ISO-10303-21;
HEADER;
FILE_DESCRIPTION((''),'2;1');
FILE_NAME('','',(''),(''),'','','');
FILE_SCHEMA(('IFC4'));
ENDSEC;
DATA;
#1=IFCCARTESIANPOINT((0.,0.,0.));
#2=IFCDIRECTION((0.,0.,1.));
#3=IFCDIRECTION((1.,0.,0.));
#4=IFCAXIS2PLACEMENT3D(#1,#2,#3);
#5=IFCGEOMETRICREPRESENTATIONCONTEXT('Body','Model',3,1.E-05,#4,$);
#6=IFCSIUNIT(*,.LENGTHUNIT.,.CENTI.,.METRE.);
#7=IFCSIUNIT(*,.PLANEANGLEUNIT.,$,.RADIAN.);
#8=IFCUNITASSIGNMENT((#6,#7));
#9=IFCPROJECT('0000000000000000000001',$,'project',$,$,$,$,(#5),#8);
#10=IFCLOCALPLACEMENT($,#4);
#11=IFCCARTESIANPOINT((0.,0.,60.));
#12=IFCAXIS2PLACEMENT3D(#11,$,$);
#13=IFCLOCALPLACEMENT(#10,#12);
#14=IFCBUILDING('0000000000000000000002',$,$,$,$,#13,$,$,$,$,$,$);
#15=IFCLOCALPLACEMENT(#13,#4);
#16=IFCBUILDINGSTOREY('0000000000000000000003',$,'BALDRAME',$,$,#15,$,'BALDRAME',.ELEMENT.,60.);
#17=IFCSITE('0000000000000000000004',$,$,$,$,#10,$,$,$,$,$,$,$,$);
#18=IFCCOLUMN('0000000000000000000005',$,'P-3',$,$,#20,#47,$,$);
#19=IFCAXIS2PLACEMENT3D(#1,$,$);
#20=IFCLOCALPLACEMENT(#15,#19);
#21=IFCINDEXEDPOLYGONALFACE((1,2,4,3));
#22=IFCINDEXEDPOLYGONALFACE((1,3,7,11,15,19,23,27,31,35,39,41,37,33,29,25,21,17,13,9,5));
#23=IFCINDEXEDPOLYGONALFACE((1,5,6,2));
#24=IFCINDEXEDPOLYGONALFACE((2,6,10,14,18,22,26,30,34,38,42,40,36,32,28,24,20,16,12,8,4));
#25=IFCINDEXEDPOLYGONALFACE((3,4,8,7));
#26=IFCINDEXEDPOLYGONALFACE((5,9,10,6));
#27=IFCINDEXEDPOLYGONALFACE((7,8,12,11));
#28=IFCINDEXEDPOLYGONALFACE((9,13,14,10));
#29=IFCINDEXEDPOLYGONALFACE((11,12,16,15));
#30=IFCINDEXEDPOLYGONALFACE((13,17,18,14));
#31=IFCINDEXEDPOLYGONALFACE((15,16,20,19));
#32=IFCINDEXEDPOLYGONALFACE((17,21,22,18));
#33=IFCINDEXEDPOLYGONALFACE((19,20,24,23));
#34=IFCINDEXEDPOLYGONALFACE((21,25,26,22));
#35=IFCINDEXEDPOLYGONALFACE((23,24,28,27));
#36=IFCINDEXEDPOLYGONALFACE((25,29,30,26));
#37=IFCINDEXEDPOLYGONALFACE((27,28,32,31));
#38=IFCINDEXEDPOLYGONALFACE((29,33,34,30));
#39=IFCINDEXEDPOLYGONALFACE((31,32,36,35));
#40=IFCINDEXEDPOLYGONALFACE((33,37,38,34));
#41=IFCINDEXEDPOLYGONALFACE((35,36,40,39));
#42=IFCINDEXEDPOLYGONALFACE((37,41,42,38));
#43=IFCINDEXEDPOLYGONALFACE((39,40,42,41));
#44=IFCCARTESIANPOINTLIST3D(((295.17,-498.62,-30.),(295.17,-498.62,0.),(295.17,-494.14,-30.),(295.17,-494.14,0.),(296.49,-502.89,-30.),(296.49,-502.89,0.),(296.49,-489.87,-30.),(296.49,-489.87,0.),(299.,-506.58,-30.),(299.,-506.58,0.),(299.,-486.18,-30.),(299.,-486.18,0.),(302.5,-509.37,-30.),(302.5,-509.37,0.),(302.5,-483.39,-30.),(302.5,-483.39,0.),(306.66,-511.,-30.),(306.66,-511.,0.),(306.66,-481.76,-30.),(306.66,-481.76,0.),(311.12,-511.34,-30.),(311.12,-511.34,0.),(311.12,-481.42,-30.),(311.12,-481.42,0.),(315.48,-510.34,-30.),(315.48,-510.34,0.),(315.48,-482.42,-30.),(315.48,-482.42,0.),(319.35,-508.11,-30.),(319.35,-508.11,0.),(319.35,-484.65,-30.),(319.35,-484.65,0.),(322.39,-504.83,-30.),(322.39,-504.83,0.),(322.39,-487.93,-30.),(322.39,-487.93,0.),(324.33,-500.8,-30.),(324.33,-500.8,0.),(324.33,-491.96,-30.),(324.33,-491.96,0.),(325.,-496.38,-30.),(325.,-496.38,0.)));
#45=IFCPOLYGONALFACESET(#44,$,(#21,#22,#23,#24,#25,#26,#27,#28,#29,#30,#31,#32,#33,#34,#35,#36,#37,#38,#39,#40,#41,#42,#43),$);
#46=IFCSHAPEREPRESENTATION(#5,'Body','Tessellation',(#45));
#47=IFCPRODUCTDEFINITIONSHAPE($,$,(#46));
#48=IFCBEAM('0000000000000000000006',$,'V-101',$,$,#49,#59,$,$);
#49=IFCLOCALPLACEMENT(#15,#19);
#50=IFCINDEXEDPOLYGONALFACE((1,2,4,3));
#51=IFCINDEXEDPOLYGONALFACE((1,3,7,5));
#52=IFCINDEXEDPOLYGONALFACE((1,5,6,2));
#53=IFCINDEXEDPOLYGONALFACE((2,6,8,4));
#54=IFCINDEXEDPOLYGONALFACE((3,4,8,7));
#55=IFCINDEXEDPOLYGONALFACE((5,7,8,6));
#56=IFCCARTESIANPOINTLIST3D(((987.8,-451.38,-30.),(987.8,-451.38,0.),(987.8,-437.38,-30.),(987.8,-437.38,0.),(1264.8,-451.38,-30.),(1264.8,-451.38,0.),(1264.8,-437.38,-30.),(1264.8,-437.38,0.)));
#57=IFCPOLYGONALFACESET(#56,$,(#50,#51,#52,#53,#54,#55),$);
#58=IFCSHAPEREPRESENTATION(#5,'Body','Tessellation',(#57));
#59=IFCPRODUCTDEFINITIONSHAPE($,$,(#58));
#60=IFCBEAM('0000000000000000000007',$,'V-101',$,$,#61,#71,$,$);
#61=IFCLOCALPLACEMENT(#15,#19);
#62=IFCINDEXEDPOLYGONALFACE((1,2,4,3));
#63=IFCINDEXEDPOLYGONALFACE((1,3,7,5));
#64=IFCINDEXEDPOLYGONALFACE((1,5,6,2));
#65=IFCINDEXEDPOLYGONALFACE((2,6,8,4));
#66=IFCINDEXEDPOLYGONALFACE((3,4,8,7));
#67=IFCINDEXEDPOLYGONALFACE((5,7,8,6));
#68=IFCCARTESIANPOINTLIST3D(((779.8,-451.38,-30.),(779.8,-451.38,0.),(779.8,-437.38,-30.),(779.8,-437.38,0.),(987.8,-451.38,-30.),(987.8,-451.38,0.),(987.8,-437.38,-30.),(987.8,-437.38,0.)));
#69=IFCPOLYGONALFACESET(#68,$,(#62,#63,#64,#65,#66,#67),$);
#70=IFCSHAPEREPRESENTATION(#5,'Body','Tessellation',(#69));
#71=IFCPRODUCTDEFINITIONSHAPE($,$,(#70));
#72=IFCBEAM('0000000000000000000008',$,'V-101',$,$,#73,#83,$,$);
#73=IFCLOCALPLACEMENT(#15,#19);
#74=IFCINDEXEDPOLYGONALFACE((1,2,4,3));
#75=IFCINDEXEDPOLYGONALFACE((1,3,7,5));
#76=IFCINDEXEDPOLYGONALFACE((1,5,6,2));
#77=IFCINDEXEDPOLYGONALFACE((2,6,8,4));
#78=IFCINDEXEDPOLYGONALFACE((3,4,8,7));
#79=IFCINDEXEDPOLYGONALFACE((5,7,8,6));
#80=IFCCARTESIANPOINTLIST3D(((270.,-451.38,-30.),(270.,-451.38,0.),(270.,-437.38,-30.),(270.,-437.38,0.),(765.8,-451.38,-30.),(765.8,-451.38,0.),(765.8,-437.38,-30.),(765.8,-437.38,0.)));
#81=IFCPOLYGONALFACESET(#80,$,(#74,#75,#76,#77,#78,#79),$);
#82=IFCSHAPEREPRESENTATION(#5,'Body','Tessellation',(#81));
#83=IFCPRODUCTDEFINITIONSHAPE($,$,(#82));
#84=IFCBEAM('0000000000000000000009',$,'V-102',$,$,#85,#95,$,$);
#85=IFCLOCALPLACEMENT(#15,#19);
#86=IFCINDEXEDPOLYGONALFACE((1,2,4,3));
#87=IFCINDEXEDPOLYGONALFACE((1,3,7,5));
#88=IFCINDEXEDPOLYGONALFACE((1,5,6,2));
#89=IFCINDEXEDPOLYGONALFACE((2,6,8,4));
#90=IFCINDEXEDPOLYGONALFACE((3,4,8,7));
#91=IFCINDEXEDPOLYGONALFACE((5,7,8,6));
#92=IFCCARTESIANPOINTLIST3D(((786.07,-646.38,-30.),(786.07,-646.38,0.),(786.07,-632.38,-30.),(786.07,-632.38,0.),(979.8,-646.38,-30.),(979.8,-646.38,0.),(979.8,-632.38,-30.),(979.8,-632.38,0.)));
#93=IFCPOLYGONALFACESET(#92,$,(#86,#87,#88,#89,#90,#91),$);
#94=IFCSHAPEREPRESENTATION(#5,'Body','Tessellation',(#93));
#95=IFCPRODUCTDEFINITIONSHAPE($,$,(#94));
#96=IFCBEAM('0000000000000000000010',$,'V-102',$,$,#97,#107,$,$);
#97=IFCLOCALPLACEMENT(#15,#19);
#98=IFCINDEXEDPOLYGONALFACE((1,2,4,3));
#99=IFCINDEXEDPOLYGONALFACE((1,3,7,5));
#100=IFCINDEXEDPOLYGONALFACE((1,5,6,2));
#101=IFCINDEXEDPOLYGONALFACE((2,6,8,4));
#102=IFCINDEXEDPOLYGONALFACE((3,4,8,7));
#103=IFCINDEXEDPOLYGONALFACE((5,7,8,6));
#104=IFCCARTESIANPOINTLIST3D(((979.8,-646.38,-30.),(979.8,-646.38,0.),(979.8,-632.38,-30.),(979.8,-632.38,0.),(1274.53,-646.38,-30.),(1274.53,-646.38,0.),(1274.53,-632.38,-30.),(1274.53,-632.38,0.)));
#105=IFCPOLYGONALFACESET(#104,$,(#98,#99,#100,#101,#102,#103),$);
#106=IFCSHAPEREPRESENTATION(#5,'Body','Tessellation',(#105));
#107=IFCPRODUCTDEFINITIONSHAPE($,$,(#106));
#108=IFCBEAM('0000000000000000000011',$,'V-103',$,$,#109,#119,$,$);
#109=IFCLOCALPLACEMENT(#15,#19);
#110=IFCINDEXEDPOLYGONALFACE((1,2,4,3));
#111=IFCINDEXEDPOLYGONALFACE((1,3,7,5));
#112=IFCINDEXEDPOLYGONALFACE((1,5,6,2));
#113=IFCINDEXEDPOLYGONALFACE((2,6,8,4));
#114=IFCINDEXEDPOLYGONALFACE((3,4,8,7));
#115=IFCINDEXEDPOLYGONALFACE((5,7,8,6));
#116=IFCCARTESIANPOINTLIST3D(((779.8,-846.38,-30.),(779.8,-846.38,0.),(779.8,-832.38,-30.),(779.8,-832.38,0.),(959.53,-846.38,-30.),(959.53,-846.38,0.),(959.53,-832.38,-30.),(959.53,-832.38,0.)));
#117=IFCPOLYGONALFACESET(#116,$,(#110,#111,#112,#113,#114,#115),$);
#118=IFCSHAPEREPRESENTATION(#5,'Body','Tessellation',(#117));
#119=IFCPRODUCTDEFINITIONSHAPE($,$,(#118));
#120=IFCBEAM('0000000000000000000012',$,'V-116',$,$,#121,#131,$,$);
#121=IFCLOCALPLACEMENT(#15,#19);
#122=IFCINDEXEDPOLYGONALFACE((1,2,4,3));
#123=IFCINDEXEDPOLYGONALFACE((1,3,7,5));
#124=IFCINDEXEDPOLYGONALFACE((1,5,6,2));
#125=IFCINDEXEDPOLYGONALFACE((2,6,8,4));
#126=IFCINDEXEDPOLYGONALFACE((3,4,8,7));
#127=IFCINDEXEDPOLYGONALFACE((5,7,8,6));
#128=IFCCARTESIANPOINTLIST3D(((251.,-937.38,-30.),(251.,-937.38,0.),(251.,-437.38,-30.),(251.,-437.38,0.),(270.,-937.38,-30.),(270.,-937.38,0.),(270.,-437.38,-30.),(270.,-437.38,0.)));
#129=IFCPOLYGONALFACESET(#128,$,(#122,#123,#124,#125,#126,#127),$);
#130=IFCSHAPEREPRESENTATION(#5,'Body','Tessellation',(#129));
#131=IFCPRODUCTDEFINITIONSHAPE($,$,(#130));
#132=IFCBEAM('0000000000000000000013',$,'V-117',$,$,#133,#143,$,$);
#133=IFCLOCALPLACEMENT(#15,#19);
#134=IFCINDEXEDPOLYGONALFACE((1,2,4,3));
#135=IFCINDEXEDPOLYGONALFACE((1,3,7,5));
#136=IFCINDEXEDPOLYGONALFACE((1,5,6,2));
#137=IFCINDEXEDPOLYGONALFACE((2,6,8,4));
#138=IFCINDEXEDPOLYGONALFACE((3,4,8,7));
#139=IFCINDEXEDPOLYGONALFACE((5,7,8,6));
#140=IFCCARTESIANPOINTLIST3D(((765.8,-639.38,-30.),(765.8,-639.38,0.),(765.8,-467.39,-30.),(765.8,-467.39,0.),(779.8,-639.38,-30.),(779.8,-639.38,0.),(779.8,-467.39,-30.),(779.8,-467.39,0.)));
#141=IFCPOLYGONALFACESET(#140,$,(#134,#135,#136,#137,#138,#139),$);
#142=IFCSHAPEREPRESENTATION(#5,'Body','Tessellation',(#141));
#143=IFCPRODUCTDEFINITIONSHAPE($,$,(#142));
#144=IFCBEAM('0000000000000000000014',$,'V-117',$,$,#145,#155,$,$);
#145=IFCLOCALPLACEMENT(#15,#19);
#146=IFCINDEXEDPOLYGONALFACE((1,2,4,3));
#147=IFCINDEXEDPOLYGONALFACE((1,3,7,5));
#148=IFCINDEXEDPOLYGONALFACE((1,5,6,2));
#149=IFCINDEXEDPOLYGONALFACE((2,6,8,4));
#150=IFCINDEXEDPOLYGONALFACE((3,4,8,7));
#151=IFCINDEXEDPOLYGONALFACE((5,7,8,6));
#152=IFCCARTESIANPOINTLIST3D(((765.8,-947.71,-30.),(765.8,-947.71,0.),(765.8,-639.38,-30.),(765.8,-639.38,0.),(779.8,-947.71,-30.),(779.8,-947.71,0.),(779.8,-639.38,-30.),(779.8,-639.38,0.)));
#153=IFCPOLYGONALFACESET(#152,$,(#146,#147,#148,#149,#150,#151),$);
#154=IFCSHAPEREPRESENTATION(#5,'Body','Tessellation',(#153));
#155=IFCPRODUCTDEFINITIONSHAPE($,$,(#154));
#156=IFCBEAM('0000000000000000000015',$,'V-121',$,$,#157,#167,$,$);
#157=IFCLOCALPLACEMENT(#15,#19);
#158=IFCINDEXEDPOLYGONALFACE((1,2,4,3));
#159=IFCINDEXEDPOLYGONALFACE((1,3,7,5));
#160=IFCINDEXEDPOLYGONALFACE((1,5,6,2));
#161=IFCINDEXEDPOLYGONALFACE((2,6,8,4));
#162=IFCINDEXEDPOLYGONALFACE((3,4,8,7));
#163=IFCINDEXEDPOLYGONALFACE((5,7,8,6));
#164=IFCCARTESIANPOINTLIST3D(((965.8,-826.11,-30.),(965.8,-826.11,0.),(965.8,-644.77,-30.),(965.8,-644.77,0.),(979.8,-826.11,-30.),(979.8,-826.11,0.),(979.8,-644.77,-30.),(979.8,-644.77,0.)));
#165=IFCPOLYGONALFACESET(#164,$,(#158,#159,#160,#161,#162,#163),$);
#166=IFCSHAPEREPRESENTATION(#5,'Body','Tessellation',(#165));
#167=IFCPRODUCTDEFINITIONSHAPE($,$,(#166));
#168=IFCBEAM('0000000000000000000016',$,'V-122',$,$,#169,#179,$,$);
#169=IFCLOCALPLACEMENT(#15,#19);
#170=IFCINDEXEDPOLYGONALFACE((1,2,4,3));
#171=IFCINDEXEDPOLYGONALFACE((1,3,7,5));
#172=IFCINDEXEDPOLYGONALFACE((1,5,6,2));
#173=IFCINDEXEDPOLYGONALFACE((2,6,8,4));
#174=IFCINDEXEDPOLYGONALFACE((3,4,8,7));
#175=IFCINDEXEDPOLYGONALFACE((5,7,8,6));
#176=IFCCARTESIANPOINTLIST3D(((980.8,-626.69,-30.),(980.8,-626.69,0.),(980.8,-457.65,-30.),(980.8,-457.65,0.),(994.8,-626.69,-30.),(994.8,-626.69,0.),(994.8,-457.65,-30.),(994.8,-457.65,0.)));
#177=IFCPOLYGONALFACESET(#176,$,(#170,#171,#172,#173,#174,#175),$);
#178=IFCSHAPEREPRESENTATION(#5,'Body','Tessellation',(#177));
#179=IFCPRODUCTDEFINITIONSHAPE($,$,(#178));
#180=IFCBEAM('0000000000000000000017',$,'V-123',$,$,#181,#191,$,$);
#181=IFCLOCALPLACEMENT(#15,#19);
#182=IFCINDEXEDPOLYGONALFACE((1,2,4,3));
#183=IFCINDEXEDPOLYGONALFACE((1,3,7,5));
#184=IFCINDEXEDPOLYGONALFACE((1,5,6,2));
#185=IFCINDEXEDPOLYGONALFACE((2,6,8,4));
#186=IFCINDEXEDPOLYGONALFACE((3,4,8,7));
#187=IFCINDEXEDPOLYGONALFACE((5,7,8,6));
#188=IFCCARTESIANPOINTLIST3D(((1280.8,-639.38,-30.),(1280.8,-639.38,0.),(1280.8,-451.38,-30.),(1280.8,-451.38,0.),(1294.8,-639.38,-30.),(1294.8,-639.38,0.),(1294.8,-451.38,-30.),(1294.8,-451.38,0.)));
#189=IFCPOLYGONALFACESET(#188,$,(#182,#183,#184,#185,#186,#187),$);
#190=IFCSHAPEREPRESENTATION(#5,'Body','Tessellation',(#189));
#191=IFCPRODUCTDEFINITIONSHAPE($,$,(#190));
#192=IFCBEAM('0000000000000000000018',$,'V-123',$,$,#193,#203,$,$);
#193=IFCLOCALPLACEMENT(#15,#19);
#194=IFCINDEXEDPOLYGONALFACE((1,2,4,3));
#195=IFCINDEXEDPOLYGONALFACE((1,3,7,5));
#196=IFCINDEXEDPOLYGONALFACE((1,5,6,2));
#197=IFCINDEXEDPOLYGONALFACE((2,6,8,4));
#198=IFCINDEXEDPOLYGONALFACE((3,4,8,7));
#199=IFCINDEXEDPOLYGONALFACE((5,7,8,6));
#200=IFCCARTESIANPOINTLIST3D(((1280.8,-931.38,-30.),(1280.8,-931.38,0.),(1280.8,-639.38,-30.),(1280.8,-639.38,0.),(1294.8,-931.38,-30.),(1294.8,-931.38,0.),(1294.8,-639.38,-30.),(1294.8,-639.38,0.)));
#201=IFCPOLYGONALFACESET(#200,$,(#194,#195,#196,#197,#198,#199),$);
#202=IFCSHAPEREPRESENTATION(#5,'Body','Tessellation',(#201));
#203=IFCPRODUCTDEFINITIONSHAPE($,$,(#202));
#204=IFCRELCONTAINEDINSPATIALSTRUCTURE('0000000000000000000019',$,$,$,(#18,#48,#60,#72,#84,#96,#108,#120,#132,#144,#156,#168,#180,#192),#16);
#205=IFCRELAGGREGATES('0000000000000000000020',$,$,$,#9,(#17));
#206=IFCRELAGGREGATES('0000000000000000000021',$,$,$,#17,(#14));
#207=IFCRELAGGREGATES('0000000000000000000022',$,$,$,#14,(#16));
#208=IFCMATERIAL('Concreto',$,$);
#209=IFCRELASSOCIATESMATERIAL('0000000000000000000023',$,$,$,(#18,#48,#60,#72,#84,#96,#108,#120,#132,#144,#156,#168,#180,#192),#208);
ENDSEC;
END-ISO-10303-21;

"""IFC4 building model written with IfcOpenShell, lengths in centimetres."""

from ifc_helpers import new_model, si_unit, frame, origin_with_axes, origin_2d_with_axis, place, context, project, spatial, rectangle, circle, extrude, material, element, save


model = new_model("IFC4")

# Units and contexts
model_context = context("Model", 3, precision=1e-05, world=origin_with_axes(), identifier="Body")
ifc_project = project(units=[si_unit("LENGTHUNIT", "METRE", prefix="CENTI"), si_unit("PLANEANGLEUNIT", "RADIAN")], contexts=[model_context])

# Site, building, storey
site_placement = place(None, origin_with_axes())
site = spatial("IfcSite", under=ifc_project, at=site_placement)
building_placement = place(site_placement, frame((0.0, 0.0, 60.0)))
building = spatial("IfcBuilding", under=site, at=building_placement)
storey_placement = place(building_placement, origin_with_axes())
storey = spatial("IfcBuildingStorey", under=building, at=storey_placement, Name="BALDRAME", LongName="BALDRAME", CompositionType="ELEMENT", Elevation=60.0)

# Shared definitions
ifc_material = material(Name="Concreto")

# Column
column_1_placement = place(storey_placement, frame((310.0, -496.38, 0.0), z_axis=(0.0, 0.0, 1.0), x_axis=(1.0, 0.0, 0.0)))
element("IfcColumn", 1, at=column_1_placement, inside=storey, material=ifc_material, Name="P-3", context=model_context, shape_type="SolidModel", body=[
    extrude(circle(Radius=15.0, at=origin_2d_with_axis()), frame((0.0, 0.0, -30.0), z_axis=(0.0, 0.0, 1.0), x_axis=(1.0, 0.0, 0.0)), (0.0, 0.0, 1.0), 30.0),
])

# Beams
beam_1_placement = place(storey_placement, frame((1126.3, -444.38, 0.0), z_axis=(0.0, 0.0, 1.0), x_axis=(1.0, 0.0, 0.0)))
element("IfcBeam", 2, at=beam_1_placement, inside=storey, material=ifc_material, Name="V-101", context=model_context, shape_type="SolidModel", body=[
    extrude(rectangle(XDim=14.0, YDim=30.0, at=origin_2d_with_axis()), frame((-138.5, 0.0, -15.0), z_axis=(1.0, 0.0, 0.0), x_axis=(0.0, 1.0, 0.0)), (0.0, 0.0, 1.0), 277.0),
])
beam_2_placement = place(storey_placement, frame((883.8, -444.38, 0.0), z_axis=(0.0, 0.0, 1.0), x_axis=(1.0, 0.0, 0.0)))
element("IfcBeam", 3, at=beam_2_placement, inside=storey, material=ifc_material, Name="V-101", context=model_context, shape_type="SolidModel", body=[
    extrude(rectangle(XDim=14.0, YDim=30.0, at=origin_2d_with_axis()), frame((-104.0, 0.0, -15.0), z_axis=(1.0, 0.0, 0.0), x_axis=(0.0, 1.0, 0.0)), (0.0, 0.0, 1.0), 208.0),
])
beam_3_placement = place(storey_placement, frame((517.9, -444.38, 0.0), z_axis=(0.0, 0.0, 1.0), x_axis=(1.0, 0.0, 0.0)))
element("IfcBeam", 4, at=beam_3_placement, inside=storey, material=ifc_material, Name="V-101", context=model_context, shape_type="SolidModel", body=[
    extrude(rectangle(XDim=14.0, YDim=30.0, at=origin_2d_with_axis()), frame((-247.9, 0.0, -15.0), z_axis=(1.0, 0.0, 0.0), x_axis=(0.0, -1.0, 0.0)), (0.0, 0.0, 1.0), 495.8),
])
beam_4_placement = place(storey_placement, frame((882.93, -639.38, 0.0), z_axis=(0.0, 0.0, 1.0), x_axis=(1.0, 0.0, 0.0)))
element("IfcBeam", 5, at=beam_4_placement, inside=storey, material=ifc_material, Name="V-102", context=model_context, shape_type="SolidModel", body=[
    extrude(rectangle(XDim=14.0, YDim=30.0, at=origin_2d_with_axis()), frame((-96.87, 0.0, -15.0), z_axis=(1.0, 0.0, 0.0), x_axis=(0.0, -1.0, 0.0)), (0.0, 0.0, 1.0), 193.73),
])
beam_5_placement = place(storey_placement, frame((1127.17, -639.38, 0.0), z_axis=(0.0, 0.0, 1.0), x_axis=(1.0, 0.0, 0.0)))
element("IfcBeam", 6, at=beam_5_placement, inside=storey, material=ifc_material, Name="V-102", context=model_context, shape_type="SolidModel", body=[
    extrude(rectangle(XDim=14.0, YDim=30.0, at=origin_2d_with_axis()), frame((-147.37, 0.0, -15.0), z_axis=(1.0, 0.0, 0.0), x_axis=(0.0, -1.0, 0.0)), (0.0, 0.0, 1.0), 294.73),
])
beam_6_placement = place(storey_placement, frame((869.67, -839.38, 0.0), z_axis=(0.0, 0.0, 1.0), x_axis=(1.0, 0.0, 0.0)))
element("IfcBeam", 7, at=beam_6_placement, inside=storey, material=ifc_material, Name="V-103", context=model_context, shape_type="SolidModel", body=[
    extrude(rectangle(XDim=14.0, YDim=30.0, at=origin_2d_with_axis()), frame((-89.87, 0.0, -15.0), z_axis=(1.0, 0.0, 0.0), x_axis=(0.0, -1.0, 0.0)), (0.0, 0.0, 1.0), 179.73),
])
beam_7_placement = place(storey_placement, frame((260.5, -687.38, 0.0), z_axis=(0.0, 0.0, 1.0), x_axis=(1.0, 0.0, 0.0)))
element("IfcBeam", 8, at=beam_7_placement, inside=storey, material=ifc_material, Name="V-116", context=model_context, shape_type="SolidModel", body=[
    extrude(rectangle(XDim=19.0, YDim=30.0, at=origin_2d_with_axis()), frame((0.0, -250.0, -15.0), z_axis=(0.0, 1.0, 0.0), x_axis=(1.0, 0.0, 0.0)), (0.0, 0.0, 1.0), 500.0),
])
beam_8_placement = place(storey_placement, frame((772.8, -553.38, 0.0), z_axis=(0.0, 0.0, 1.0), x_axis=(1.0, 0.0, 0.0)))
element("IfcBeam", 9, at=beam_8_placement, inside=storey, material=ifc_material, Name="V-117", context=model_context, shape_type="SolidModel", body=[
    extrude(rectangle(XDim=14.0, YDim=30.0, at=origin_2d_with_axis()), frame((0.0, -86.0, -15.0), z_axis=(0.0, 1.0, 0.0), x_axis=(1.0, 0.0, 0.0)), (0.0, 0.0, 1.0), 171.99),
])
beam_9_placement = place(storey_placement, frame((772.8, -793.54, 0.0), z_axis=(0.0, 0.0, 1.0), x_axis=(1.0, 0.0, 0.0)))
element("IfcBeam", 10, at=beam_9_placement, inside=storey, material=ifc_material, Name="V-117", context=model_context, shape_type="SolidModel", body=[
    extrude(rectangle(XDim=14.0, YDim=30.0, at=origin_2d_with_axis()), frame((0.0, -154.16, -15.0), z_axis=(0.0, 1.0, 0.0), x_axis=(1.0, 0.0, 0.0)), (0.0, 0.0, 1.0), 308.33),
])
beam_10_placement = place(storey_placement, frame((972.8, -735.44, 0.0), z_axis=(0.0, 0.0, 1.0), x_axis=(1.0, 0.0, 0.0)))
element("IfcBeam", 11, at=beam_10_placement, inside=storey, material=ifc_material, Name="V-121", context=model_context, shape_type="SolidModel", body=[
    extrude(rectangle(XDim=14.0, YDim=30.0, at=origin_2d_with_axis()), frame((0.0, -90.67, -15.0), z_axis=(0.0, 1.0, 0.0), x_axis=(1.0, 0.0, 0.0)), (0.0, 0.0, 1.0), 181.35),
])
beam_11_placement = place(storey_placement, frame((987.8, -542.17, 0.0), z_axis=(0.0, 0.0, 1.0), x_axis=(1.0, 0.0, 0.0)))
element("IfcBeam", 12, at=beam_11_placement, inside=storey, material=ifc_material, Name="V-122", context=model_context, shape_type="SolidModel", body=[
    extrude(rectangle(XDim=14.0, YDim=30.0, at=origin_2d_with_axis()), frame((0.0, -84.52, -15.0), z_axis=(0.0, 1.0, 0.0), x_axis=(1.0, 0.0, 0.0)), (0.0, 0.0, 1.0), 169.04),
])
beam_12_placement = place(storey_placement, frame((1287.8, -545.38, 0.0), z_axis=(0.0, 0.0, 1.0), x_axis=(1.0, 0.0, 0.0)))
element("IfcBeam", 13, at=beam_12_placement, inside=storey, material=ifc_material, Name="V-123", context=model_context, shape_type="SolidModel", body=[
    extrude(rectangle(XDim=14.0, YDim=30.0, at=origin_2d_with_axis()), frame((0.0, -94.0, -15.0), z_axis=(0.0, 1.0, 0.0), x_axis=(1.0, 0.0, 0.0)), (0.0, 0.0, 1.0), 188.0),
])
beam_13_placement = place(storey_placement, frame((1287.8, -785.38, 0.0), z_axis=(0.0, 0.0, 1.0), x_axis=(1.0, 0.0, 0.0)))
element("IfcBeam", 14, at=beam_13_placement, inside=storey, material=ifc_material, Name="V-123", context=model_context, shape_type="SolidModel", body=[
    extrude(rectangle(XDim=14.0, YDim=30.0, at=origin_2d_with_axis()), frame((0.0, -146.0, -15.0), z_axis=(0.0, 1.0, 0.0), x_axis=(1.0, 0.0, 0.0)), (0.0, 0.0, 1.0), 292.0),
])

save(model, "model.ifc")
